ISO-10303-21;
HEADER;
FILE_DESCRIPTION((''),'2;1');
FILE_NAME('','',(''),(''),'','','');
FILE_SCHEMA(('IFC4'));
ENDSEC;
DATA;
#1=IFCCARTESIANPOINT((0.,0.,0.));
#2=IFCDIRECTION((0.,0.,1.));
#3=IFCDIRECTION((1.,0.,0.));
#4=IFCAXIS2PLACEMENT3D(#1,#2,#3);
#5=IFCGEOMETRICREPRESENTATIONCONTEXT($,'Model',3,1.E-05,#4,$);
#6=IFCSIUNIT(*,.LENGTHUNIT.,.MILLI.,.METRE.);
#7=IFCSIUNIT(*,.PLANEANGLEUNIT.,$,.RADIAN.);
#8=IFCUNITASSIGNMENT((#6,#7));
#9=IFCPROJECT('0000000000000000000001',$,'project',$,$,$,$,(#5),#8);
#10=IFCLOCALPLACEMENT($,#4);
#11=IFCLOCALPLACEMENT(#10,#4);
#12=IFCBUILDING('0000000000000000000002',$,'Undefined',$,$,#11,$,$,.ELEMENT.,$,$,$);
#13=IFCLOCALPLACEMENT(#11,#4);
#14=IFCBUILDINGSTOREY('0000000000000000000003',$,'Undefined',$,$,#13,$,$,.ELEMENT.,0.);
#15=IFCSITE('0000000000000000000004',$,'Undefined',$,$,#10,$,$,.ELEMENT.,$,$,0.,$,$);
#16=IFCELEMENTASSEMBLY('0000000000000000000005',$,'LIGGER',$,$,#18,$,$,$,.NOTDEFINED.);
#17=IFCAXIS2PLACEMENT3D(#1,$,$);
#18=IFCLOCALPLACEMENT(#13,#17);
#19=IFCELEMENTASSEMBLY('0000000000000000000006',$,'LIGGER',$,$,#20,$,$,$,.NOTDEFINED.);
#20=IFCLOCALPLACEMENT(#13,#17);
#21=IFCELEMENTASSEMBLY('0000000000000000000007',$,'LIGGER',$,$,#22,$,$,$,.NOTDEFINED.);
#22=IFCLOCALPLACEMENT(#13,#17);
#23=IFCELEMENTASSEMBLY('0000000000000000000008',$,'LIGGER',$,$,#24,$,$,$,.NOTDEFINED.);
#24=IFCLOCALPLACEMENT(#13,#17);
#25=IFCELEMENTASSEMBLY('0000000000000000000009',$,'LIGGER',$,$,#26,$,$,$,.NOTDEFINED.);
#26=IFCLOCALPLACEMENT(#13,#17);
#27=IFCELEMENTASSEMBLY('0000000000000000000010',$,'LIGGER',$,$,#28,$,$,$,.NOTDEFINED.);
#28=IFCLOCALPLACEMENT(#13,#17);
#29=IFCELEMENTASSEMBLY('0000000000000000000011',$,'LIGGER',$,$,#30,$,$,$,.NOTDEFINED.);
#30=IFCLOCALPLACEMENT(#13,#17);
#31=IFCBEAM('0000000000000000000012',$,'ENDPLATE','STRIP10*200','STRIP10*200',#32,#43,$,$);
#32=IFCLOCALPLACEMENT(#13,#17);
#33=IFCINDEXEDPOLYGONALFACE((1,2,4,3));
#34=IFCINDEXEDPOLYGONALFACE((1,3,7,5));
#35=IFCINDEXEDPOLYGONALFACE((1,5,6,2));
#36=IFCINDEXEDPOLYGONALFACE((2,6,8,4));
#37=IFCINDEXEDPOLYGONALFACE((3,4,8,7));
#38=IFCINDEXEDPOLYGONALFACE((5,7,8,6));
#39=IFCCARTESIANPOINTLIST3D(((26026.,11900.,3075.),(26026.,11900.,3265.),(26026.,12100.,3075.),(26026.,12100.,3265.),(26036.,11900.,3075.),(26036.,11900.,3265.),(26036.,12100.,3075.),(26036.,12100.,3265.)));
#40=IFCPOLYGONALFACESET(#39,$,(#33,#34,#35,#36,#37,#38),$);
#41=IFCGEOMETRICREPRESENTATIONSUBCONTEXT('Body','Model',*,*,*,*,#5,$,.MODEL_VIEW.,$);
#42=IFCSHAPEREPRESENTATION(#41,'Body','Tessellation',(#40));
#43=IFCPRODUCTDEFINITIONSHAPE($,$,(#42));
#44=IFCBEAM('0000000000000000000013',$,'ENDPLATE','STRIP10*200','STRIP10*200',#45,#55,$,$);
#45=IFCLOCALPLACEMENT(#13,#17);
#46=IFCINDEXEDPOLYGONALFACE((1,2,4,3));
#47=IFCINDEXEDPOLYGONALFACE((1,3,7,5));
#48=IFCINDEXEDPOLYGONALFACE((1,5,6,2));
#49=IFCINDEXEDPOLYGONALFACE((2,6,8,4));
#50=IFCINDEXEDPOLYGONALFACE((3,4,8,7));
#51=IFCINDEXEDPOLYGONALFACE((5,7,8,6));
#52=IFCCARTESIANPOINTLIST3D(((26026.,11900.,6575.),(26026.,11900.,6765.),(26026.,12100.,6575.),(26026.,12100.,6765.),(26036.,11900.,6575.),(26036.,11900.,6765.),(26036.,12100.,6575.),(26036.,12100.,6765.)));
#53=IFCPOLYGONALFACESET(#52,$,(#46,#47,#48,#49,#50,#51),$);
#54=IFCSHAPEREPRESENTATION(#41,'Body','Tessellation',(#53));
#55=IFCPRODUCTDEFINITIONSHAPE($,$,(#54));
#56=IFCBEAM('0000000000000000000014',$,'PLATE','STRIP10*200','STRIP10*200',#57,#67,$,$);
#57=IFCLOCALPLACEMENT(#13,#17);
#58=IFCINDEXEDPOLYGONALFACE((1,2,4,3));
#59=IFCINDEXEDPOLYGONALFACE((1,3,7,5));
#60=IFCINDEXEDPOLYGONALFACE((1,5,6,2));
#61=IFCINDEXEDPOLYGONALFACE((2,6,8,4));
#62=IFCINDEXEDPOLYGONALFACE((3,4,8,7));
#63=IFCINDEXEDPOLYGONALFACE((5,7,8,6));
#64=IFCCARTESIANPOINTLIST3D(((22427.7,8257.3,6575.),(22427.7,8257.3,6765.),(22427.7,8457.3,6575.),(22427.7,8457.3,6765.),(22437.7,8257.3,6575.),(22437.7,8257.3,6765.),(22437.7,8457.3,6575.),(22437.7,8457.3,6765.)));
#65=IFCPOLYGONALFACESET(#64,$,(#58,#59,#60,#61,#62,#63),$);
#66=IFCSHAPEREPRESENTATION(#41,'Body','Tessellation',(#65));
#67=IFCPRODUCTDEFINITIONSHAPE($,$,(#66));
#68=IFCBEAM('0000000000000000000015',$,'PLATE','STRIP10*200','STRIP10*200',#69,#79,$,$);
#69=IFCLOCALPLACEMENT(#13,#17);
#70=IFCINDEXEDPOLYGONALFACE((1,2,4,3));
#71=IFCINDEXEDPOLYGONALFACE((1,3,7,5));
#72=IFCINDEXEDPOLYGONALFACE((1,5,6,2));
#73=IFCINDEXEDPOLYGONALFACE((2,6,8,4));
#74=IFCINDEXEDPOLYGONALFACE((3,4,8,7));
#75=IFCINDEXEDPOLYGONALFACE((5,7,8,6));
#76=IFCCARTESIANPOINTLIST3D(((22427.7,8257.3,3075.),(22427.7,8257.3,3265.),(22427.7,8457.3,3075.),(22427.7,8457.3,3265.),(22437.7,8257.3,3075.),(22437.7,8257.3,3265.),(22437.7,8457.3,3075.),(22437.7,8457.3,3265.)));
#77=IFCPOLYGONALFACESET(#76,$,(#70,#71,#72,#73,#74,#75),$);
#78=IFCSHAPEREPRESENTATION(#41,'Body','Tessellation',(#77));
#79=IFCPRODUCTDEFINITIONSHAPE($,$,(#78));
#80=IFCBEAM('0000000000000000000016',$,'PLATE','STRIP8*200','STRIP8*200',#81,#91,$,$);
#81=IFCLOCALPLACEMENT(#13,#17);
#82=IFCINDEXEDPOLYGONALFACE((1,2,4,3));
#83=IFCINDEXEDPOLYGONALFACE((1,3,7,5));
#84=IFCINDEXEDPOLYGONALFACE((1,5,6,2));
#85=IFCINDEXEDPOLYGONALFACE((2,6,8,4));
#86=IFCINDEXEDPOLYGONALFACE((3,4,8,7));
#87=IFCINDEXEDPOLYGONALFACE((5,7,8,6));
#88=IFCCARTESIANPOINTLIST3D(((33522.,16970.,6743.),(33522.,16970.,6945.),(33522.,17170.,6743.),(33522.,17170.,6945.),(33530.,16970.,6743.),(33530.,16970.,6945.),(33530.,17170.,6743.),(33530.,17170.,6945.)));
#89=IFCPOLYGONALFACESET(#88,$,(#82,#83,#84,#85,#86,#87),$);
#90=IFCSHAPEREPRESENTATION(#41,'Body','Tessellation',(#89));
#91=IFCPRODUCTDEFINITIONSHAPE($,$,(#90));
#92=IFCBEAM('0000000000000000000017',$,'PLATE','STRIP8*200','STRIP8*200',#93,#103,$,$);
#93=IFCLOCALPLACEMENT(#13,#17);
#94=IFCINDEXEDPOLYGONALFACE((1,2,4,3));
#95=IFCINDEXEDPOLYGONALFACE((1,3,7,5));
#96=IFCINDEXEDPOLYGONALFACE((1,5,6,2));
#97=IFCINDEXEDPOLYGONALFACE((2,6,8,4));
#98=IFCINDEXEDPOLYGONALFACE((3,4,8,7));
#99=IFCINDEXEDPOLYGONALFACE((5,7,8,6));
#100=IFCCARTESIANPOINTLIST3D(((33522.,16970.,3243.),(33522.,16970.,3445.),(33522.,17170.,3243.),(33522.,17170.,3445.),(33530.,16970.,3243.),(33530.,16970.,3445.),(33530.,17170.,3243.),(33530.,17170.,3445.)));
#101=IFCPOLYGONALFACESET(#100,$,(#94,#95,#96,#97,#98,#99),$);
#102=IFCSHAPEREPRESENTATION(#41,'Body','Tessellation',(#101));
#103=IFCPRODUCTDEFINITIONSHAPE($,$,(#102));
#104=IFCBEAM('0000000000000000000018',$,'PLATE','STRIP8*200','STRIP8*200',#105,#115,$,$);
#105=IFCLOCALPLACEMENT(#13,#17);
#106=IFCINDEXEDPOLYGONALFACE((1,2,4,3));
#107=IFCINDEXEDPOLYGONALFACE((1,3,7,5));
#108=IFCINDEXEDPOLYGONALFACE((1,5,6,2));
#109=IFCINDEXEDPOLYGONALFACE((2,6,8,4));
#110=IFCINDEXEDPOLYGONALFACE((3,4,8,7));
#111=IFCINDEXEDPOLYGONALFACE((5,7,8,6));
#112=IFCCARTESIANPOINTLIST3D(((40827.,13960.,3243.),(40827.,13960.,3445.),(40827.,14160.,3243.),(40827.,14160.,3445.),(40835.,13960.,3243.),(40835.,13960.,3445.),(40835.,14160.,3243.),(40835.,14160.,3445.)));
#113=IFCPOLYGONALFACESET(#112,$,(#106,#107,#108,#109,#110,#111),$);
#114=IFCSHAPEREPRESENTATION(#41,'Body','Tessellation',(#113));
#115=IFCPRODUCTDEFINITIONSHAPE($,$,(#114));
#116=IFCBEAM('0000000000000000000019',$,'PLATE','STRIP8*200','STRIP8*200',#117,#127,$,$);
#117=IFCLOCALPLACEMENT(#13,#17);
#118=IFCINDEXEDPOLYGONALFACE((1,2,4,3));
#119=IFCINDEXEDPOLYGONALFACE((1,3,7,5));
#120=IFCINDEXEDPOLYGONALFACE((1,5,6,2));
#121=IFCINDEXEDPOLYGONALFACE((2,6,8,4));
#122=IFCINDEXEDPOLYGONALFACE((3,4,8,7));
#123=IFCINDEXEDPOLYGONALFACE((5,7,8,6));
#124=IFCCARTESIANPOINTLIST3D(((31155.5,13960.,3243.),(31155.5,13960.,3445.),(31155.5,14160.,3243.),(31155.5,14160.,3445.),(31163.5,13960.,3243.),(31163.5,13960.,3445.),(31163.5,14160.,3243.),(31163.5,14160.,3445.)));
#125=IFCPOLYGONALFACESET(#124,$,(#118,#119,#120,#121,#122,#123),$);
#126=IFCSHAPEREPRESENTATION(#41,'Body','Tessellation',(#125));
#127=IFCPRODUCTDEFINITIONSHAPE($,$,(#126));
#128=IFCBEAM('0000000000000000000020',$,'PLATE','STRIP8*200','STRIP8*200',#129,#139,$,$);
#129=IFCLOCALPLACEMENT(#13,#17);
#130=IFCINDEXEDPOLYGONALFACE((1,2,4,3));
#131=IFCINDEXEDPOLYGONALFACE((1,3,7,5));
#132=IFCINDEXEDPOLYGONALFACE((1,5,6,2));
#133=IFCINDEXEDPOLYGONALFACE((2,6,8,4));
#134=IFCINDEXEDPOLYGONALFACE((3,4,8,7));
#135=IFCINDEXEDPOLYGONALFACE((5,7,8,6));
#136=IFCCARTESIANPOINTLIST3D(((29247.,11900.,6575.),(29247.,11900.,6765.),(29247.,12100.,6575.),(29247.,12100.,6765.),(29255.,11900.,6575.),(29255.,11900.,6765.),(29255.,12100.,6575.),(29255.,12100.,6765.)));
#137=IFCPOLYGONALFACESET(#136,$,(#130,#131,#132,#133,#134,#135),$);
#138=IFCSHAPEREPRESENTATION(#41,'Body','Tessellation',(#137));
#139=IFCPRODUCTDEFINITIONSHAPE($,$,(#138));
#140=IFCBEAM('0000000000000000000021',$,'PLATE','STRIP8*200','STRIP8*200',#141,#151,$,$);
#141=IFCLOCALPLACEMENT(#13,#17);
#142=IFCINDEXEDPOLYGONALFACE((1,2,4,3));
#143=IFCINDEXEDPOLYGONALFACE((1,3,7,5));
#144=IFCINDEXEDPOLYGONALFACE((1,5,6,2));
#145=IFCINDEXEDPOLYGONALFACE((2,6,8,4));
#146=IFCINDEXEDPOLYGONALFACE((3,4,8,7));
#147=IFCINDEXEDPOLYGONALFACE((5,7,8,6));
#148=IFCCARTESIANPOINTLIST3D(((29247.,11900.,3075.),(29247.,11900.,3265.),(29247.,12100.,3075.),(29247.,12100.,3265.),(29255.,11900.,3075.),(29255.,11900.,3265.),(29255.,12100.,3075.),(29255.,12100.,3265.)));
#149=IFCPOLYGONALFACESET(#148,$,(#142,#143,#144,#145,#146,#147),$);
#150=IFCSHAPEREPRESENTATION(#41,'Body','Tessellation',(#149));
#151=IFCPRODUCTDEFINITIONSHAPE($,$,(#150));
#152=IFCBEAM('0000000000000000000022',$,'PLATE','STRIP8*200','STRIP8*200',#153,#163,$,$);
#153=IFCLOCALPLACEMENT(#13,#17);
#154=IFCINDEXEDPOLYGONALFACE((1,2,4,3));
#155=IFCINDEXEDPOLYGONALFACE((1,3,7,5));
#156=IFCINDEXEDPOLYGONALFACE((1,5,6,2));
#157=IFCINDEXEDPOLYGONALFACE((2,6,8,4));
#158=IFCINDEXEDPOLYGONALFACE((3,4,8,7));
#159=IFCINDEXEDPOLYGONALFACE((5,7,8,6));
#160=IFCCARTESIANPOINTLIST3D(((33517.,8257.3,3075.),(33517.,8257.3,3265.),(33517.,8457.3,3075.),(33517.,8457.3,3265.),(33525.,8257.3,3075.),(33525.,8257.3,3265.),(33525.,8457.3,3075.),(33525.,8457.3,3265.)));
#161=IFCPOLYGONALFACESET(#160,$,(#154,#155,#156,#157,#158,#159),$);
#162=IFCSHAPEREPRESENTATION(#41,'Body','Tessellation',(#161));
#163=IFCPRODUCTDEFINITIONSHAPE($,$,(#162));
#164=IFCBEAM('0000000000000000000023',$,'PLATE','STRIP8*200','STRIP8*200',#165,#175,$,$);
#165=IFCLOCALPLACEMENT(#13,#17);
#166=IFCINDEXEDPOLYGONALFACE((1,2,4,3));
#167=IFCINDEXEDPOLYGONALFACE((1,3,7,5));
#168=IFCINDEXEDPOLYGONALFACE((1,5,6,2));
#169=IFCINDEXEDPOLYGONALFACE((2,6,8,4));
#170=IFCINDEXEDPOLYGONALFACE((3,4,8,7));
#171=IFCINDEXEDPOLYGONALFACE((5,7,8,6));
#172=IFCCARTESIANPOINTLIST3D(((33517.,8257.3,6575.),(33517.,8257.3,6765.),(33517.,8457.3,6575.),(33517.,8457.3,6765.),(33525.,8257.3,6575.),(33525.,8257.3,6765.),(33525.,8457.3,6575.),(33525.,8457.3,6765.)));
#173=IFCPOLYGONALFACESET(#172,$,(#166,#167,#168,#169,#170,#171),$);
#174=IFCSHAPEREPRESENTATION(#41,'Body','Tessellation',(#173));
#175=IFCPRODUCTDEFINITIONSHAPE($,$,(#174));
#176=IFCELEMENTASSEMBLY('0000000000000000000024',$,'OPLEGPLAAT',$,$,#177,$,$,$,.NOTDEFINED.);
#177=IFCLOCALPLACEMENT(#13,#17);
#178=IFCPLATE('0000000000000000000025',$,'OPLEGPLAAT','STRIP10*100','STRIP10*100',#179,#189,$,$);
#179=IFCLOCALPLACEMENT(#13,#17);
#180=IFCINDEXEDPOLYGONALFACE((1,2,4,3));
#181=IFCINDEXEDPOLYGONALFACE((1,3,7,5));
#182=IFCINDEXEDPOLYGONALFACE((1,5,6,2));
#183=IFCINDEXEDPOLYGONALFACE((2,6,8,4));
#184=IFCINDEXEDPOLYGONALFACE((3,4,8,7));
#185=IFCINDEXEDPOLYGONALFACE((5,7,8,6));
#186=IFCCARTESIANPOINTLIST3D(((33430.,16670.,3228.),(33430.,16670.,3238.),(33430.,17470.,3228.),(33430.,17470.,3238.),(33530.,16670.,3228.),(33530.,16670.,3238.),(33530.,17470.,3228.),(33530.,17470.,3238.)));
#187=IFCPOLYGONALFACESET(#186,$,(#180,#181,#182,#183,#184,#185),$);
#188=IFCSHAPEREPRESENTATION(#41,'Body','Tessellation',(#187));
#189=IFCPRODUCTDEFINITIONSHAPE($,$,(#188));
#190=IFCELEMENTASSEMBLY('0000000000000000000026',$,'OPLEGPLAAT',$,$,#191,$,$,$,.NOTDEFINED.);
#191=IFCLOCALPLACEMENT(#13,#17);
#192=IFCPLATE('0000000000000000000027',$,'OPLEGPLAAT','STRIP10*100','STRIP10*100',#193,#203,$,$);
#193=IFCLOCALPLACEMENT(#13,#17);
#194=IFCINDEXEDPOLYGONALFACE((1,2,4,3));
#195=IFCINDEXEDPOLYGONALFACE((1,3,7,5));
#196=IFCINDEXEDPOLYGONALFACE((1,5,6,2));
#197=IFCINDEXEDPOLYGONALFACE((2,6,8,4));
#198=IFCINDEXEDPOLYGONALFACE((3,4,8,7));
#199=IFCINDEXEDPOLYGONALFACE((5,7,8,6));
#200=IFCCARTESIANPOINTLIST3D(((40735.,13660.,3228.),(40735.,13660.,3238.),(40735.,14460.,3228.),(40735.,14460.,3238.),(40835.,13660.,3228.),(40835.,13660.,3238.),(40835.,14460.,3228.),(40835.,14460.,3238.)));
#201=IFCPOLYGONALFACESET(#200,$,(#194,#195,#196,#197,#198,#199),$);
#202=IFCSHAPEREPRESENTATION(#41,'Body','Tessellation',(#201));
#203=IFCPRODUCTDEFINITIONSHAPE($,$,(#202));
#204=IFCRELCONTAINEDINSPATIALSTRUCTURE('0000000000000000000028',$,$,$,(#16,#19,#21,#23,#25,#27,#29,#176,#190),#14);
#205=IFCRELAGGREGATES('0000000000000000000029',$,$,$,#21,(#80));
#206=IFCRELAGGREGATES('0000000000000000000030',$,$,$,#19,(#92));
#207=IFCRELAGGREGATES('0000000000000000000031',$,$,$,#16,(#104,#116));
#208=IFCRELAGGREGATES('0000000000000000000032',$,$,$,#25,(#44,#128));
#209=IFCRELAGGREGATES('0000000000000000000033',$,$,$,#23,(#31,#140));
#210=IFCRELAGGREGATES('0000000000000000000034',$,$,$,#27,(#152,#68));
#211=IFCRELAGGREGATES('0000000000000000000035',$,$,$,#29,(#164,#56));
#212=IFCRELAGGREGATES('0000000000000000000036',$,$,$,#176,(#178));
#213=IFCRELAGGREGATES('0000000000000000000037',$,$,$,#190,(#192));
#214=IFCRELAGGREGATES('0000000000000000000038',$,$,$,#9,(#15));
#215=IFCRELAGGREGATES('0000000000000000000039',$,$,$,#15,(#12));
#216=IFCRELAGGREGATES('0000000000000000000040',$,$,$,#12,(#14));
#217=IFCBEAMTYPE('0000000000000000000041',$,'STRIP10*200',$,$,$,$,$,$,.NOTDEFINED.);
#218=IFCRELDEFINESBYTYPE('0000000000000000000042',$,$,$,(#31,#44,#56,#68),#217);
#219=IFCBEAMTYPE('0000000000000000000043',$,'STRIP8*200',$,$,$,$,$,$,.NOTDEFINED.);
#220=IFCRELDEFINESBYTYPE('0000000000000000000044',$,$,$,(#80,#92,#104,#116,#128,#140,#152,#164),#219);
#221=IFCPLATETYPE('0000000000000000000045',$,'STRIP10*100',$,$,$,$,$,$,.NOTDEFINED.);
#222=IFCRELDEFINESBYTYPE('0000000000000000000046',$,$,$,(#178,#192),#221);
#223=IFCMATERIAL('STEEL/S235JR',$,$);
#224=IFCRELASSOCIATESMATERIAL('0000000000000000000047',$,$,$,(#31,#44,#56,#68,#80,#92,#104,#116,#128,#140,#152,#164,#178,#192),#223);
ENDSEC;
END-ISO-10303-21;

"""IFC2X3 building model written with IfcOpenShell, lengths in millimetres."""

from ifc_helpers import new_model, si_unit, frame, origin_with_axes, origin_2d_with_axis, place, context, subcontext, project, spatial, rectangle, extrude, material, type_object, element, aggregate, save


model = new_model("IFC2X3")

# Units and contexts
model_context = context("Model", 3, precision=1e-05, world=origin_with_axes())
body_context = subcontext(model_context, "Body", "Model", "MODEL_VIEW")
ifc_project = project(units=[si_unit("LENGTHUNIT", "METRE", prefix="MILLI"), si_unit("PLANEANGLEUNIT", "RADIAN")], contexts=[model_context])

# Site, building, storey
site_placement = place(None, origin_with_axes())
site = spatial("IfcSite", under=ifc_project, at=site_placement, Name="Undefined", CompositionType="ELEMENT", RefElevation=0.0)
building_placement = place(site_placement, origin_with_axes())
building = spatial("IfcBuilding", under=site, at=building_placement, Name="Undefined", CompositionType="ELEMENT")
storey_placement = place(building_placement, origin_with_axes())
storey = spatial("IfcBuildingStorey", under=building, at=storey_placement, Name="Undefined", CompositionType="ELEMENT", Elevation=0.0)

# Shared definitions
ifc_material = material(Name="STEEL/S235JR")

# Element assemblies
assembly_1_placement = place(storey_placement, origin_with_axes())
assembly_1 = element("IfcElementAssembly", 1, at=assembly_1_placement, inside=storey, Name="LIGGER", PredefinedType="NOTDEFINED")
assembly_2_placement = place(storey_placement, origin_with_axes())
assembly_2 = element("IfcElementAssembly", 2, at=assembly_2_placement, inside=storey, Name="LIGGER", PredefinedType="NOTDEFINED")
assembly_3_placement = place(storey_placement, origin_with_axes())
assembly_3 = element("IfcElementAssembly", 3, at=assembly_3_placement, inside=storey, Name="LIGGER", PredefinedType="NOTDEFINED")
assembly_4_placement = place(storey_placement, origin_with_axes())
assembly_4 = element("IfcElementAssembly", 4, at=assembly_4_placement, inside=storey, Name="LIGGER", PredefinedType="NOTDEFINED")
assembly_5_placement = place(storey_placement, origin_with_axes())
assembly_5 = element("IfcElementAssembly", 5, at=assembly_5_placement, inside=storey, Name="LIGGER", PredefinedType="NOTDEFINED")
assembly_6_placement = place(storey_placement, origin_with_axes())
assembly_6 = element("IfcElementAssembly", 6, at=assembly_6_placement, inside=storey, Name="LIGGER", PredefinedType="NOTDEFINED")
assembly_7_placement = place(storey_placement, origin_with_axes())
assembly_7 = element("IfcElementAssembly", 7, at=assembly_7_placement, inside=storey, Name="LIGGER", PredefinedType="NOTDEFINED")

# Beams
beam_type_1 = type_object("IfcBeamType", Name="STRIP10*200", PredefinedType="NOTDEFINED")
beam_1_placement = place(assembly_4_placement, frame((26031.0, 12000.0, 3075.0), z_axis=(0.0, -1.0, 0.0), x_axis=(0.0, 0.0, 1.0)))
beam_1 = element("IfcBeam", 8, at=beam_1_placement, type_object=beam_type_1, material=ifc_material, Name="ENDPLATE", Description="STRIP10*200", ObjectType="STRIP10*200", context=body_context, shape_type="SweptSolid", body=[
    extrude(rectangle(XDim=10.0, YDim=200.0, at=origin_2d_with_axis()), frame((190.0, 0.0, 0.0), z_axis=(-1.0, 0.0, 0.0), x_axis=(0.0, -1.0, 0.0)), (0.0, 0.0, 1.0), 190.0),
])
beam_2_placement = place(assembly_5_placement, frame((26031.0, 12000.0, 6575.0), z_axis=(0.0, -1.0, 0.0), x_axis=(0.0, 0.0, 1.0)))
beam_2 = element("IfcBeam", 9, at=beam_2_placement, type_object=beam_type_1, material=ifc_material, Name="ENDPLATE", Description="STRIP10*200", ObjectType="STRIP10*200", context=body_context, shape_type="SweptSolid", body=[
    extrude(rectangle(XDim=10.0, YDim=200.0, at=origin_2d_with_axis()), frame((190.0, 0.0, 0.0), z_axis=(-1.0, 0.0, 0.0), x_axis=(0.0, -1.0, 0.0)), (0.0, 0.0, 1.0), 190.0),
])
beam_3_placement = place(assembly_7_placement, frame((22432.7, 8357.3, 6575.0), z_axis=(0.0, -1.0, 0.0), x_axis=(0.0, 0.0, 1.0)))
beam_3 = element("IfcBeam", 10, at=beam_3_placement, type_object=beam_type_1, material=ifc_material, Name="PLATE", Description="STRIP10*200", ObjectType="STRIP10*200", context=body_context, shape_type="SweptSolid", body=[
    extrude(rectangle(XDim=10.0, YDim=200.0, at=origin_2d_with_axis()), frame((190.0, 0.0, 0.0), z_axis=(-1.0, 0.0, 0.0), x_axis=(0.0, -1.0, 0.0)), (0.0, 0.0, 1.0), 190.0),
])
beam_4_placement = place(assembly_6_placement, frame((22432.7, 8357.3, 3075.0), z_axis=(0.0, -1.0, 0.0), x_axis=(0.0, 0.0, 1.0)))
beam_4 = element("IfcBeam", 11, at=beam_4_placement, type_object=beam_type_1, material=ifc_material, Name="PLATE", Description="STRIP10*200", ObjectType="STRIP10*200", context=body_context, shape_type="SweptSolid", body=[
    extrude(rectangle(XDim=10.0, YDim=200.0, at=origin_2d_with_axis()), frame((190.0, 0.0, 0.0), z_axis=(-1.0, 0.0, 0.0), x_axis=(0.0, -1.0, 0.0)), (0.0, 0.0, 1.0), 190.0),
])
beam_type_2 = type_object("IfcBeamType", Name="STRIP8*200", PredefinedType="NOTDEFINED")
beam_5_placement = place(assembly_3_placement, frame((33526.0, 17070.0, 6743.0), z_axis=(0.0, 1.0, 0.0), x_axis=(0.0, 0.0, 1.0)))
beam_5 = element("IfcBeam", 12, at=beam_5_placement, type_object=beam_type_2, material=ifc_material, Name="PLATE", Description="STRIP8*200", ObjectType="STRIP8*200", context=body_context, shape_type="SweptSolid", body=[
    extrude(rectangle(XDim=8.0, YDim=200.0, at=origin_2d_with_axis()), frame((202.0, 0.0, 0.0), z_axis=(-1.0, 0.0, 0.0), x_axis=(0.0, -1.0, 0.0)), (0.0, 0.0, 1.0), 202.0),
])
aggregate(assembly_3, [beam_5])
beam_6_placement = place(assembly_2_placement, frame((33526.0, 17070.0, 3243.0), z_axis=(0.0, 1.0, 0.0), x_axis=(0.0, 0.0, 1.0)))
beam_6 = element("IfcBeam", 13, at=beam_6_placement, type_object=beam_type_2, material=ifc_material, Name="PLATE", Description="STRIP8*200", ObjectType="STRIP8*200", context=body_context, shape_type="SweptSolid", body=[
    extrude(rectangle(XDim=8.0, YDim=200.0, at=origin_2d_with_axis()), frame((202.0, 0.0, 0.0), z_axis=(-1.0, 0.0, 0.0), x_axis=(0.0, -1.0, 0.0)), (0.0, 0.0, 1.0), 202.0),
])
aggregate(assembly_2, [beam_6])
beam_7_placement = place(assembly_1_placement, frame((40831.0, 14060.0, 3243.0), z_axis=(0.0, 1.0, 0.0), x_axis=(0.0, 0.0, 1.0)))
beam_7 = element("IfcBeam", 14, at=beam_7_placement, type_object=beam_type_2, material=ifc_material, Name="PLATE", Description="STRIP8*200", ObjectType="STRIP8*200", context=body_context, shape_type="SweptSolid", body=[
    extrude(rectangle(XDim=8.0, YDim=200.0, at=origin_2d_with_axis()), frame((202.0, 0.0, 0.0), z_axis=(-1.0, 0.0, 0.0), x_axis=(0.0, -1.0, 0.0)), (0.0, 0.0, 1.0), 202.0),
])
beam_8_placement = place(assembly_1_placement, frame((31159.5, 14060.0, 3243.0), z_axis=(0.0, -1.0, 0.0), x_axis=(0.0, 0.0, 1.0)))
beam_8 = element("IfcBeam", 15, at=beam_8_placement, type_object=beam_type_2, material=ifc_material, Name="PLATE", Description="STRIP8*200", ObjectType="STRIP8*200", context=body_context, shape_type="SweptSolid", body=[
    extrude(rectangle(XDim=8.0, YDim=200.0, at=origin_2d_with_axis()), frame((202.0, 0.0, 0.0), z_axis=(-1.0, 0.0, 0.0), x_axis=(0.0, -1.0, 0.0)), (0.0, 0.0, 1.0), 202.0),
])
aggregate(assembly_1, [beam_7, beam_8])
beam_9_placement = place(assembly_5_placement, frame((29251.0, 12000.0, 6575.0), z_axis=(0.0, 1.0, 0.0), x_axis=(0.0, 0.0, 1.0)))
beam_9 = element("IfcBeam", 16, at=beam_9_placement, type_object=beam_type_2, material=ifc_material, Name="PLATE", Description="STRIP8*200", ObjectType="STRIP8*200", context=body_context, shape_type="SweptSolid", body=[
    extrude(rectangle(XDim=8.0, YDim=200.0, at=origin_2d_with_axis()), frame((190.0, 0.0, 0.0), z_axis=(-1.0, 0.0, 0.0), x_axis=(0.0, -1.0, 0.0)), (0.0, 0.0, 1.0), 190.0),
])
aggregate(assembly_5, [beam_2, beam_9])
beam_10_placement = place(assembly_4_placement, frame((29251.0, 12000.0, 3075.0), z_axis=(0.0, 1.0, 0.0), x_axis=(0.0, 0.0, 1.0)))
beam_10 = element("IfcBeam", 17, at=beam_10_placement, type_object=beam_type_2, material=ifc_material, Name="PLATE", Description="STRIP8*200", ObjectType="STRIP8*200", context=body_context, shape_type="SweptSolid", body=[
    extrude(rectangle(XDim=8.0, YDim=200.0, at=origin_2d_with_axis()), frame((190.0, 0.0, 0.0), z_axis=(-1.0, 0.0, 0.0), x_axis=(0.0, -1.0, 0.0)), (0.0, 0.0, 1.0), 190.0),
])
aggregate(assembly_4, [beam_1, beam_10])
beam_11_placement = place(assembly_6_placement, frame((33521.0, 8357.3, 3075.0), z_axis=(0.0, 1.0, 0.0), x_axis=(0.0, 0.0, 1.0)))
beam_11 = element("IfcBeam", 18, at=beam_11_placement, type_object=beam_type_2, material=ifc_material, Name="PLATE", Description="STRIP8*200", ObjectType="STRIP8*200", context=body_context, shape_type="SweptSolid", body=[
    extrude(rectangle(XDim=8.0, YDim=200.0, at=origin_2d_with_axis()), frame((190.0, 0.0, 0.0), z_axis=(-1.0, 0.0, 0.0), x_axis=(0.0, -1.0, 0.0)), (0.0, 0.0, 1.0), 190.0),
])
aggregate(assembly_6, [beam_11, beam_4])
beam_12_placement = place(assembly_7_placement, frame((33521.0, 8357.3, 6575.0), z_axis=(0.0, 1.0, 0.0), x_axis=(0.0, 0.0, 1.0)))
beam_12 = element("IfcBeam", 19, at=beam_12_placement, type_object=beam_type_2, material=ifc_material, Name="PLATE", Description="STRIP8*200", ObjectType="STRIP8*200", context=body_context, shape_type="SweptSolid", body=[
    extrude(rectangle(XDim=8.0, YDim=200.0, at=origin_2d_with_axis()), frame((190.0, 0.0, 0.0), z_axis=(-1.0, 0.0, 0.0), x_axis=(0.0, -1.0, 0.0)), (0.0, 0.0, 1.0), 190.0),
])
aggregate(assembly_7, [beam_12, beam_3])

# Element assemblies, plates
assembly_8_placement = place(storey_placement, origin_with_axes())
assembly_8 = element("IfcElementAssembly", 20, at=assembly_8_placement, inside=storey, Name="OPLEGPLAAT", PredefinedType="NOTDEFINED")
plate_type = type_object("IfcPlateType", Name="STRIP10*100", PredefinedType="NOTDEFINED")
plate_1_placement = place(assembly_8_placement, frame((33480.0, 16670.0, 3233.0), z_axis=(-1.0, 0.0, 0.0), x_axis=(0.0, 1.0, 0.0)))
plate_1 = element("IfcPlate", 21, at=plate_1_placement, type_object=plate_type, material=ifc_material, Name="OPLEGPLAAT", Description="STRIP10*100", ObjectType="STRIP10*100", context=body_context, shape_type="SweptSolid", body=[
    extrude(rectangle(XDim=10.0, YDim=100.0, at=origin_2d_with_axis()), frame((800.0, 0.0, 0.0), z_axis=(-1.0, 0.0, 0.0), x_axis=(0.0, -1.0, 0.0)), (0.0, 0.0, 1.0), 800.0),
])
aggregate(assembly_8, [plate_1])
assembly_9_placement = place(storey_placement, origin_with_axes())
assembly_9 = element("IfcElementAssembly", 22, at=assembly_9_placement, inside=storey, Name="OPLEGPLAAT", PredefinedType="NOTDEFINED")
plate_2_placement = place(assembly_9_placement, frame((40785.0, 13660.0, 3233.0), z_axis=(-1.0, 0.0, 0.0), x_axis=(0.0, 1.0, 0.0)))
plate_2 = element("IfcPlate", 23, at=plate_2_placement, type_object=plate_type, material=ifc_material, Name="OPLEGPLAAT", Description="STRIP10*100", ObjectType="STRIP10*100", context=body_context, shape_type="SweptSolid", body=[
    extrude(rectangle(XDim=10.0, YDim=100.0, at=origin_2d_with_axis()), frame((800.0, 0.0, 0.0), z_axis=(-1.0, 0.0, 0.0), x_axis=(0.0, -1.0, 0.0)), (0.0, 0.0, 1.0), 800.0),
])
aggregate(assembly_9, [plate_2])

save(model, "model.ifc")
